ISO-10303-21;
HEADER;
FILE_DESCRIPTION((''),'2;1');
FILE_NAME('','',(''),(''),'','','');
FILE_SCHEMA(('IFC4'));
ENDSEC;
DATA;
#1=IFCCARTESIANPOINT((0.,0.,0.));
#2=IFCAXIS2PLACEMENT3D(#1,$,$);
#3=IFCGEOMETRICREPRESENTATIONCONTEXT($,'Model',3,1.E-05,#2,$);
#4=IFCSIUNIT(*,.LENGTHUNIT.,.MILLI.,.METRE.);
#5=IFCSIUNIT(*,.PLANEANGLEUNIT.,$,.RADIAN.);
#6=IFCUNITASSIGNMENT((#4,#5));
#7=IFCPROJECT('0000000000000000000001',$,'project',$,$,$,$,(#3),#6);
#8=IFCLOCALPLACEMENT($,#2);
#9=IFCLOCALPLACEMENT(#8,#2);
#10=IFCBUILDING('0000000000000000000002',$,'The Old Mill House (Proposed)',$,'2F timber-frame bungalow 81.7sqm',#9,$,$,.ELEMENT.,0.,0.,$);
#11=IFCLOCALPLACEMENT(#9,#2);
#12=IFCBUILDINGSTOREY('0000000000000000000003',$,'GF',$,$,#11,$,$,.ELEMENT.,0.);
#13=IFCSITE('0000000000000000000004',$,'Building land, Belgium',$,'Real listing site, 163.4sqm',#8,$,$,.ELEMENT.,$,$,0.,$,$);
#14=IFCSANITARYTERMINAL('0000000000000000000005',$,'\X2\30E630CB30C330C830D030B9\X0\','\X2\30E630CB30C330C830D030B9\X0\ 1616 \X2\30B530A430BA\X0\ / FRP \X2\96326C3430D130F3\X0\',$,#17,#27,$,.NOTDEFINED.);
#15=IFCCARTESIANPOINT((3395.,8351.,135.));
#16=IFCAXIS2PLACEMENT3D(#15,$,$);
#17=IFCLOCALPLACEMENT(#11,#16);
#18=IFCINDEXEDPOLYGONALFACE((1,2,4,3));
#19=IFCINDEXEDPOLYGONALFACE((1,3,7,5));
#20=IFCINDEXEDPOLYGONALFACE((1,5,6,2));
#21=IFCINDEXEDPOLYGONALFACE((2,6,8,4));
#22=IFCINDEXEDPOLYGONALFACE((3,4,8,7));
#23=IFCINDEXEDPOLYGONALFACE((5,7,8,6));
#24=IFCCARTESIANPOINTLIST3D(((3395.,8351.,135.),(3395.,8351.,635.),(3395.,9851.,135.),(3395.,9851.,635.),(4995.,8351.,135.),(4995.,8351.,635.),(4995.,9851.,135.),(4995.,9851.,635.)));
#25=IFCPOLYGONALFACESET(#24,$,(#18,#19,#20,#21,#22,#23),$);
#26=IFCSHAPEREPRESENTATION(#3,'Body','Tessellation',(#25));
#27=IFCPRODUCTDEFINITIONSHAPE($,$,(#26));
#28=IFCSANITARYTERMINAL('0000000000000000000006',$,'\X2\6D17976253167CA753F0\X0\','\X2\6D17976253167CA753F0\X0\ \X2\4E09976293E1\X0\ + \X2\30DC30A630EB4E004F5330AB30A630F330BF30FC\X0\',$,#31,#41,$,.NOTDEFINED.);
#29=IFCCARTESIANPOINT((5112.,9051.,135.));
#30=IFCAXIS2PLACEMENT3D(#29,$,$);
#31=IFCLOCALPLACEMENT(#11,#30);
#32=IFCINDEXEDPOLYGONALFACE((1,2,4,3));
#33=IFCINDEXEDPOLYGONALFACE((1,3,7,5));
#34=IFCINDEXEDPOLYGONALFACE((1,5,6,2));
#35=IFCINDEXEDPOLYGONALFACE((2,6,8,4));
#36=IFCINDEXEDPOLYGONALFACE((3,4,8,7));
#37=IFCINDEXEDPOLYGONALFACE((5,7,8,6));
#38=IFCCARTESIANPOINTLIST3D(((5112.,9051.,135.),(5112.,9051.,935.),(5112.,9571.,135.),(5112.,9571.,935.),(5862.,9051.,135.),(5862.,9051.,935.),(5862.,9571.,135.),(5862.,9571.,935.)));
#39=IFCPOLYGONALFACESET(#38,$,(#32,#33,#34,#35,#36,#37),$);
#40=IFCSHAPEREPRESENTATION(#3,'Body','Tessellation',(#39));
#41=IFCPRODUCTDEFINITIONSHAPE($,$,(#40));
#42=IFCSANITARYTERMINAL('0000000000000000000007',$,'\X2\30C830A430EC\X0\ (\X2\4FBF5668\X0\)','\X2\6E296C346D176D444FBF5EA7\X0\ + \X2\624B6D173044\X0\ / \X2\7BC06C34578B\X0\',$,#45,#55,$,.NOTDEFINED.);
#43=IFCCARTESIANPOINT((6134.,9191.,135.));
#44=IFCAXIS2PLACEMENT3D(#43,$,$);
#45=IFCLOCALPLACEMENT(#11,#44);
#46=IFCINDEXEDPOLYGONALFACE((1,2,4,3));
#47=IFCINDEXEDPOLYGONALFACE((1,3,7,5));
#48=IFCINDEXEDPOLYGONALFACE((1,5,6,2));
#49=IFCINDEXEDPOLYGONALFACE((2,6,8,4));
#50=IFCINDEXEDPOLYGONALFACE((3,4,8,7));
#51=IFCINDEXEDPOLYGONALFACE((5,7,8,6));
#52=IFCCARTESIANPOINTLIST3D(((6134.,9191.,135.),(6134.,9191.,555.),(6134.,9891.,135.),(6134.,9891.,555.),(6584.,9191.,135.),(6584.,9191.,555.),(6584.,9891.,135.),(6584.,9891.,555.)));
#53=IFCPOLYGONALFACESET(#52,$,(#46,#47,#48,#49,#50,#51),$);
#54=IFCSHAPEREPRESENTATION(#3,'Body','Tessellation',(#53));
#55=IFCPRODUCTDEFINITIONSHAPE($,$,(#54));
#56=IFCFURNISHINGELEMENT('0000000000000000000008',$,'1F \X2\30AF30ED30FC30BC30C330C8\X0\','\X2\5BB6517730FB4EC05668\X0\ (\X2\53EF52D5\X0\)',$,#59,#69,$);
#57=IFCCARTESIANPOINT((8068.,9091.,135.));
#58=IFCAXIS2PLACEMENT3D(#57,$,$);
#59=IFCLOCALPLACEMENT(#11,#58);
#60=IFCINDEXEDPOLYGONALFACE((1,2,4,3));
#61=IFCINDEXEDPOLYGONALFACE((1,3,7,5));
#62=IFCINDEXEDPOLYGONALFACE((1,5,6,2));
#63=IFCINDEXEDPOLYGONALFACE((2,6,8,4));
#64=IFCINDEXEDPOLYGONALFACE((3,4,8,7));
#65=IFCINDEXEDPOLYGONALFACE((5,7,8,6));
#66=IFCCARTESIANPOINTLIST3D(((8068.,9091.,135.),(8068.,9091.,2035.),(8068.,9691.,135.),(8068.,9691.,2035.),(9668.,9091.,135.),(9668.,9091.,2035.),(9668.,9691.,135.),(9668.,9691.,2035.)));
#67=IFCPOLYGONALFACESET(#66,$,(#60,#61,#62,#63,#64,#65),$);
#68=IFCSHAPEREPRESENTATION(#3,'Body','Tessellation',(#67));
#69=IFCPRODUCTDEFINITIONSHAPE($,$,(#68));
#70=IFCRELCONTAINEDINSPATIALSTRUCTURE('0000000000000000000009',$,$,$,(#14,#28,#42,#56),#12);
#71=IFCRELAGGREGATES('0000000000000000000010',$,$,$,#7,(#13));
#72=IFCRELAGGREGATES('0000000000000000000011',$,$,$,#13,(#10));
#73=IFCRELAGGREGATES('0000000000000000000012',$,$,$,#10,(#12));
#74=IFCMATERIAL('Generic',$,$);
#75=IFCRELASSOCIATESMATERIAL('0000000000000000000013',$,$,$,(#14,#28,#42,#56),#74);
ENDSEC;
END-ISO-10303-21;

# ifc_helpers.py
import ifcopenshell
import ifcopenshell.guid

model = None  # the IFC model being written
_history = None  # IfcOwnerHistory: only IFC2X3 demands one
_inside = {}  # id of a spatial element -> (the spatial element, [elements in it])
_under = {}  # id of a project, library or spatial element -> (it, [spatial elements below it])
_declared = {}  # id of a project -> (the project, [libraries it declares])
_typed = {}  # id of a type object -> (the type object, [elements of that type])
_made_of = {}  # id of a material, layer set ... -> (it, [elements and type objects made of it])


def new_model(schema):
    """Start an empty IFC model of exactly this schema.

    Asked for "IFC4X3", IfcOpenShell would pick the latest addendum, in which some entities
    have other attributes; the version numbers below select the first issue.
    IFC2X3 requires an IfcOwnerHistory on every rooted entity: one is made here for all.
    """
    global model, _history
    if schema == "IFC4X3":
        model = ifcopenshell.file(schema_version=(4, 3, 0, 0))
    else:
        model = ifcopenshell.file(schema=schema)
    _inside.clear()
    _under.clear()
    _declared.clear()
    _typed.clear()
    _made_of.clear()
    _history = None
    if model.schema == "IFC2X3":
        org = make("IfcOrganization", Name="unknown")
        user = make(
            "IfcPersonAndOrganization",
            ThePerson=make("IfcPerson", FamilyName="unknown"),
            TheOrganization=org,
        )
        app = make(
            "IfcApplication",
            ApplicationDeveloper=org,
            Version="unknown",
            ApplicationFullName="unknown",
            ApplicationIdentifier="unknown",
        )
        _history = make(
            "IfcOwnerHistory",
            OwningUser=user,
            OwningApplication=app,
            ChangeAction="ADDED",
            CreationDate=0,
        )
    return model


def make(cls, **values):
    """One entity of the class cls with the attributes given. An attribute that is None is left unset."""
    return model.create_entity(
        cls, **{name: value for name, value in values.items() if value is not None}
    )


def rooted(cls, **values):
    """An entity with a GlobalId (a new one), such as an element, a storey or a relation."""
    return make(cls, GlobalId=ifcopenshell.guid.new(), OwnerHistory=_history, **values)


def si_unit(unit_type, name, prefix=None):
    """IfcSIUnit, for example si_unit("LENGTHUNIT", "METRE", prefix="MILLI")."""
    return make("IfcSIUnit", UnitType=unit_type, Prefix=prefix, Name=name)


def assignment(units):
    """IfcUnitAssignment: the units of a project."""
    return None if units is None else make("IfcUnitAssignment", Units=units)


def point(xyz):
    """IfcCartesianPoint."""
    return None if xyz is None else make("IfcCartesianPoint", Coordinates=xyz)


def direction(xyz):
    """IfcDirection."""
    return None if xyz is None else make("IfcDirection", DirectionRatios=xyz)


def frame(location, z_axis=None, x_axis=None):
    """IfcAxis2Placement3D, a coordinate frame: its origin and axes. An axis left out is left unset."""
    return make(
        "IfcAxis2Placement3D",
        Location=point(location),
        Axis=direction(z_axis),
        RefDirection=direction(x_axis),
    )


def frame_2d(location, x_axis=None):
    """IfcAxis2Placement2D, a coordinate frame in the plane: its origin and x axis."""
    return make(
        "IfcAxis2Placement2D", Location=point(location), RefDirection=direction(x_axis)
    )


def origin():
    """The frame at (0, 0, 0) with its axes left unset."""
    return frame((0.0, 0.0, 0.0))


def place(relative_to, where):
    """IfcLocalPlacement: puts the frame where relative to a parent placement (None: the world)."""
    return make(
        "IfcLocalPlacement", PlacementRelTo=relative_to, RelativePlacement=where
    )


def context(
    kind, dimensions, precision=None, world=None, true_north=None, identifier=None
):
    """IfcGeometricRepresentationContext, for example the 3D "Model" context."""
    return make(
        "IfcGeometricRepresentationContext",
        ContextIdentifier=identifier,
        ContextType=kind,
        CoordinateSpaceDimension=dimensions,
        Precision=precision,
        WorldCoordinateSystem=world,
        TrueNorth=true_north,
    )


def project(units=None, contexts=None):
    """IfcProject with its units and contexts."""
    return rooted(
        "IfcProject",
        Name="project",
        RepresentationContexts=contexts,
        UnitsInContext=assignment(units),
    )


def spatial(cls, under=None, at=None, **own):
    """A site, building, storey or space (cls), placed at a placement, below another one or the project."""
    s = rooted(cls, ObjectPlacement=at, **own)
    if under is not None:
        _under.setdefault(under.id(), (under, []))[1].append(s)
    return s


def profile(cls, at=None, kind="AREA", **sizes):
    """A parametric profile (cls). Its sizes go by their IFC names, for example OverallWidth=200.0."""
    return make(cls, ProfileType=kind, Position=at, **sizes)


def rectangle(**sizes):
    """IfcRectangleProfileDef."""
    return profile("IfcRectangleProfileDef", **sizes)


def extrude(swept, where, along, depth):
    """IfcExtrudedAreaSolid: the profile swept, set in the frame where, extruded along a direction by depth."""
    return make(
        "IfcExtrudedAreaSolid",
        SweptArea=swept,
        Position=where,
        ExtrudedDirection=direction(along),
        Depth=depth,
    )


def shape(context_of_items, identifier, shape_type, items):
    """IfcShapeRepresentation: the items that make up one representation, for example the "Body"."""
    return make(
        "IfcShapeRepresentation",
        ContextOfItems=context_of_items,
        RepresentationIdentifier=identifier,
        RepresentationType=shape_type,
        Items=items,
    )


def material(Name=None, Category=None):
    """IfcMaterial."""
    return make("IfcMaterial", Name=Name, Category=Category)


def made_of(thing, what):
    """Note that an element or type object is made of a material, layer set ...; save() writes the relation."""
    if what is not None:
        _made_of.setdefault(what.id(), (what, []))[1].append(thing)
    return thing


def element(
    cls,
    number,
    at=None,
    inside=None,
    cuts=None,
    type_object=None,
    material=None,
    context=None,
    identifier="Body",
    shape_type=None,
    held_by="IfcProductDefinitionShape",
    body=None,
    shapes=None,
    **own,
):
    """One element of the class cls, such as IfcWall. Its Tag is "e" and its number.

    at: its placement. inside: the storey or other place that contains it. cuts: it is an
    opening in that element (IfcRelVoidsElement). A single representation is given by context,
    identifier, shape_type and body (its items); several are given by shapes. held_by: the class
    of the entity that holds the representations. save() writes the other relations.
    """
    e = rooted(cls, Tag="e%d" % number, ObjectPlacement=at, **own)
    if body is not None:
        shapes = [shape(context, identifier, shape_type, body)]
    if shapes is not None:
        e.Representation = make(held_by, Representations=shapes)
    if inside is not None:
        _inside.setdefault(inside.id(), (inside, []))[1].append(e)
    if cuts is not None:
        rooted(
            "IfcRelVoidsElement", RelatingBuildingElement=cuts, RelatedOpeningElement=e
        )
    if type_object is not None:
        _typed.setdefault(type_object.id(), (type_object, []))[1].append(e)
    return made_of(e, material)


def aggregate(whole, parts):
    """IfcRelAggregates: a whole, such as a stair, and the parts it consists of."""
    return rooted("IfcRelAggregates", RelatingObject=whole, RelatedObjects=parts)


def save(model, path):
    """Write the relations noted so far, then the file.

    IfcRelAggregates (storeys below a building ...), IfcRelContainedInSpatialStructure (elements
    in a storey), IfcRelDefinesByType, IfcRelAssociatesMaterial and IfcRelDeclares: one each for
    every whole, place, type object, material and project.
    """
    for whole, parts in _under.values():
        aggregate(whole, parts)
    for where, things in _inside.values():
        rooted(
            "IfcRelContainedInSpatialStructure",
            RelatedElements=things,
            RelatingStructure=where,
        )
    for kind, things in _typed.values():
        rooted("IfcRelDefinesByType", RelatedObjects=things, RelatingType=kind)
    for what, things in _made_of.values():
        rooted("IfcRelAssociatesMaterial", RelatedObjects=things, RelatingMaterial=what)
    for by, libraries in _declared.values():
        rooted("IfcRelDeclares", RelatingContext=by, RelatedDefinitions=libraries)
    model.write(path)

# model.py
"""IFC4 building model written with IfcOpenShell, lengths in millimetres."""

from ifc_helpers import new_model, si_unit, frame, frame_2d, origin, place, context, project, spatial, rectangle, extrude, material, element, save


model = new_model("IFC4")

# Units and contexts
model_context = context("Model", 3, precision=1e-05, world=origin())
ifc_project = project(units=[si_unit("LENGTHUNIT", "METRE", prefix="MILLI"), si_unit("PLANEANGLEUNIT", "RADIAN")], contexts=[model_context])

# Site, building, storey
site_placement = place(None, origin())
site = spatial("IfcSite", under=ifc_project, at=site_placement, Name="Building land, Belgium", ObjectType="Real listing site, 163.4sqm", CompositionType="ELEMENT", RefElevation=0.0)
building_placement = place(site_placement, origin())
building = spatial("IfcBuilding", under=site, at=building_placement, Name="The Old Mill House (Proposed)", ObjectType="2F timber-frame bungalow 81.7sqm", CompositionType="ELEMENT", ElevationOfRefHeight=0.0, ElevationOfTerrain=0.0)
storey_placement = place(building_placement, origin())
storey = spatial("IfcBuildingStorey", under=building, at=storey_placement, Name="GF", CompositionType="ELEMENT", Elevation=0.0)

# Shared definitions
ifc_material_1 = material(Name="Generic")

# Sanitary terminals
sanitary_terminal_1_placement = place(storey_placement, frame((3395.0, 8351.0, 135.0)))
element("IfcSanitaryTerminal", 1, at=sanitary_terminal_1_placement, inside=storey, material=ifc_material_1, Name="ユニットバス", Description="ユニットバス 1616 サイズ / FRP 防水パン", PredefinedType="NOTDEFINED", context=model_context, shape_type="SweptSolid", body=[
    extrude(rectangle(XDim=1600.0, YDim=1500.0, at=frame_2d((800.0, 750.0))), frame((3395.0, 8351.0, 135.0)), (0.0, 0.0, 1.0), 500.0),
])
sanitary_terminal_2_placement = place(storey_placement, frame((5112.0, 9051.0, 135.0)))
element("IfcSanitaryTerminal", 2, at=sanitary_terminal_2_placement, inside=storey, material=ifc_material_1, Name="洗面化粧台", Description="洗面化粧台 三面鏡 + ボウル一体カウンター", PredefinedType="NOTDEFINED", context=model_context, shape_type="SweptSolid", body=[
    extrude(rectangle(XDim=750.0, YDim=520.0, at=frame_2d((375.0, 260.0))), frame((5112.0, 9051.0, 135.0)), (0.0, 0.0, 1.0), 800.0),
])
sanitary_terminal_3_placement = place(storey_placement, frame((6134.0, 9191.0, 135.0)))
element("IfcSanitaryTerminal", 3, at=sanitary_terminal_3_placement, inside=storey, material=ifc_material_1, Name="トイレ (便器)", Description="温水洗浄便座 + 手洗い / 節水型", PredefinedType="NOTDEFINED", context=model_context, shape_type="SweptSolid", body=[
    extrude(rectangle(XDim=450.0, YDim=700.0, at=frame_2d((225.0, 350.0))), frame((6134.0, 9191.0, 135.0)), (0.0, 0.0, 1.0), 420.0),
])

# Furnishing element
furnishing_placement = place(storey_placement, frame((8068.0, 9091.0, 135.0)))
element("IfcFurnishingElement", 4, at=furnishing_placement, inside=storey, material=ifc_material_1, Name="1F クローゼット", Description="家具・什器 (可動)", context=model_context, shape_type="SweptSolid", body=[
    extrude(rectangle(XDim=1600.0, YDim=600.0, at=frame_2d((800.0, 300.0))), frame((8068.0, 9091.0, 135.0)), (0.0, 0.0, 1.0), 1900.0),
])

save(model, "model.ifc")
